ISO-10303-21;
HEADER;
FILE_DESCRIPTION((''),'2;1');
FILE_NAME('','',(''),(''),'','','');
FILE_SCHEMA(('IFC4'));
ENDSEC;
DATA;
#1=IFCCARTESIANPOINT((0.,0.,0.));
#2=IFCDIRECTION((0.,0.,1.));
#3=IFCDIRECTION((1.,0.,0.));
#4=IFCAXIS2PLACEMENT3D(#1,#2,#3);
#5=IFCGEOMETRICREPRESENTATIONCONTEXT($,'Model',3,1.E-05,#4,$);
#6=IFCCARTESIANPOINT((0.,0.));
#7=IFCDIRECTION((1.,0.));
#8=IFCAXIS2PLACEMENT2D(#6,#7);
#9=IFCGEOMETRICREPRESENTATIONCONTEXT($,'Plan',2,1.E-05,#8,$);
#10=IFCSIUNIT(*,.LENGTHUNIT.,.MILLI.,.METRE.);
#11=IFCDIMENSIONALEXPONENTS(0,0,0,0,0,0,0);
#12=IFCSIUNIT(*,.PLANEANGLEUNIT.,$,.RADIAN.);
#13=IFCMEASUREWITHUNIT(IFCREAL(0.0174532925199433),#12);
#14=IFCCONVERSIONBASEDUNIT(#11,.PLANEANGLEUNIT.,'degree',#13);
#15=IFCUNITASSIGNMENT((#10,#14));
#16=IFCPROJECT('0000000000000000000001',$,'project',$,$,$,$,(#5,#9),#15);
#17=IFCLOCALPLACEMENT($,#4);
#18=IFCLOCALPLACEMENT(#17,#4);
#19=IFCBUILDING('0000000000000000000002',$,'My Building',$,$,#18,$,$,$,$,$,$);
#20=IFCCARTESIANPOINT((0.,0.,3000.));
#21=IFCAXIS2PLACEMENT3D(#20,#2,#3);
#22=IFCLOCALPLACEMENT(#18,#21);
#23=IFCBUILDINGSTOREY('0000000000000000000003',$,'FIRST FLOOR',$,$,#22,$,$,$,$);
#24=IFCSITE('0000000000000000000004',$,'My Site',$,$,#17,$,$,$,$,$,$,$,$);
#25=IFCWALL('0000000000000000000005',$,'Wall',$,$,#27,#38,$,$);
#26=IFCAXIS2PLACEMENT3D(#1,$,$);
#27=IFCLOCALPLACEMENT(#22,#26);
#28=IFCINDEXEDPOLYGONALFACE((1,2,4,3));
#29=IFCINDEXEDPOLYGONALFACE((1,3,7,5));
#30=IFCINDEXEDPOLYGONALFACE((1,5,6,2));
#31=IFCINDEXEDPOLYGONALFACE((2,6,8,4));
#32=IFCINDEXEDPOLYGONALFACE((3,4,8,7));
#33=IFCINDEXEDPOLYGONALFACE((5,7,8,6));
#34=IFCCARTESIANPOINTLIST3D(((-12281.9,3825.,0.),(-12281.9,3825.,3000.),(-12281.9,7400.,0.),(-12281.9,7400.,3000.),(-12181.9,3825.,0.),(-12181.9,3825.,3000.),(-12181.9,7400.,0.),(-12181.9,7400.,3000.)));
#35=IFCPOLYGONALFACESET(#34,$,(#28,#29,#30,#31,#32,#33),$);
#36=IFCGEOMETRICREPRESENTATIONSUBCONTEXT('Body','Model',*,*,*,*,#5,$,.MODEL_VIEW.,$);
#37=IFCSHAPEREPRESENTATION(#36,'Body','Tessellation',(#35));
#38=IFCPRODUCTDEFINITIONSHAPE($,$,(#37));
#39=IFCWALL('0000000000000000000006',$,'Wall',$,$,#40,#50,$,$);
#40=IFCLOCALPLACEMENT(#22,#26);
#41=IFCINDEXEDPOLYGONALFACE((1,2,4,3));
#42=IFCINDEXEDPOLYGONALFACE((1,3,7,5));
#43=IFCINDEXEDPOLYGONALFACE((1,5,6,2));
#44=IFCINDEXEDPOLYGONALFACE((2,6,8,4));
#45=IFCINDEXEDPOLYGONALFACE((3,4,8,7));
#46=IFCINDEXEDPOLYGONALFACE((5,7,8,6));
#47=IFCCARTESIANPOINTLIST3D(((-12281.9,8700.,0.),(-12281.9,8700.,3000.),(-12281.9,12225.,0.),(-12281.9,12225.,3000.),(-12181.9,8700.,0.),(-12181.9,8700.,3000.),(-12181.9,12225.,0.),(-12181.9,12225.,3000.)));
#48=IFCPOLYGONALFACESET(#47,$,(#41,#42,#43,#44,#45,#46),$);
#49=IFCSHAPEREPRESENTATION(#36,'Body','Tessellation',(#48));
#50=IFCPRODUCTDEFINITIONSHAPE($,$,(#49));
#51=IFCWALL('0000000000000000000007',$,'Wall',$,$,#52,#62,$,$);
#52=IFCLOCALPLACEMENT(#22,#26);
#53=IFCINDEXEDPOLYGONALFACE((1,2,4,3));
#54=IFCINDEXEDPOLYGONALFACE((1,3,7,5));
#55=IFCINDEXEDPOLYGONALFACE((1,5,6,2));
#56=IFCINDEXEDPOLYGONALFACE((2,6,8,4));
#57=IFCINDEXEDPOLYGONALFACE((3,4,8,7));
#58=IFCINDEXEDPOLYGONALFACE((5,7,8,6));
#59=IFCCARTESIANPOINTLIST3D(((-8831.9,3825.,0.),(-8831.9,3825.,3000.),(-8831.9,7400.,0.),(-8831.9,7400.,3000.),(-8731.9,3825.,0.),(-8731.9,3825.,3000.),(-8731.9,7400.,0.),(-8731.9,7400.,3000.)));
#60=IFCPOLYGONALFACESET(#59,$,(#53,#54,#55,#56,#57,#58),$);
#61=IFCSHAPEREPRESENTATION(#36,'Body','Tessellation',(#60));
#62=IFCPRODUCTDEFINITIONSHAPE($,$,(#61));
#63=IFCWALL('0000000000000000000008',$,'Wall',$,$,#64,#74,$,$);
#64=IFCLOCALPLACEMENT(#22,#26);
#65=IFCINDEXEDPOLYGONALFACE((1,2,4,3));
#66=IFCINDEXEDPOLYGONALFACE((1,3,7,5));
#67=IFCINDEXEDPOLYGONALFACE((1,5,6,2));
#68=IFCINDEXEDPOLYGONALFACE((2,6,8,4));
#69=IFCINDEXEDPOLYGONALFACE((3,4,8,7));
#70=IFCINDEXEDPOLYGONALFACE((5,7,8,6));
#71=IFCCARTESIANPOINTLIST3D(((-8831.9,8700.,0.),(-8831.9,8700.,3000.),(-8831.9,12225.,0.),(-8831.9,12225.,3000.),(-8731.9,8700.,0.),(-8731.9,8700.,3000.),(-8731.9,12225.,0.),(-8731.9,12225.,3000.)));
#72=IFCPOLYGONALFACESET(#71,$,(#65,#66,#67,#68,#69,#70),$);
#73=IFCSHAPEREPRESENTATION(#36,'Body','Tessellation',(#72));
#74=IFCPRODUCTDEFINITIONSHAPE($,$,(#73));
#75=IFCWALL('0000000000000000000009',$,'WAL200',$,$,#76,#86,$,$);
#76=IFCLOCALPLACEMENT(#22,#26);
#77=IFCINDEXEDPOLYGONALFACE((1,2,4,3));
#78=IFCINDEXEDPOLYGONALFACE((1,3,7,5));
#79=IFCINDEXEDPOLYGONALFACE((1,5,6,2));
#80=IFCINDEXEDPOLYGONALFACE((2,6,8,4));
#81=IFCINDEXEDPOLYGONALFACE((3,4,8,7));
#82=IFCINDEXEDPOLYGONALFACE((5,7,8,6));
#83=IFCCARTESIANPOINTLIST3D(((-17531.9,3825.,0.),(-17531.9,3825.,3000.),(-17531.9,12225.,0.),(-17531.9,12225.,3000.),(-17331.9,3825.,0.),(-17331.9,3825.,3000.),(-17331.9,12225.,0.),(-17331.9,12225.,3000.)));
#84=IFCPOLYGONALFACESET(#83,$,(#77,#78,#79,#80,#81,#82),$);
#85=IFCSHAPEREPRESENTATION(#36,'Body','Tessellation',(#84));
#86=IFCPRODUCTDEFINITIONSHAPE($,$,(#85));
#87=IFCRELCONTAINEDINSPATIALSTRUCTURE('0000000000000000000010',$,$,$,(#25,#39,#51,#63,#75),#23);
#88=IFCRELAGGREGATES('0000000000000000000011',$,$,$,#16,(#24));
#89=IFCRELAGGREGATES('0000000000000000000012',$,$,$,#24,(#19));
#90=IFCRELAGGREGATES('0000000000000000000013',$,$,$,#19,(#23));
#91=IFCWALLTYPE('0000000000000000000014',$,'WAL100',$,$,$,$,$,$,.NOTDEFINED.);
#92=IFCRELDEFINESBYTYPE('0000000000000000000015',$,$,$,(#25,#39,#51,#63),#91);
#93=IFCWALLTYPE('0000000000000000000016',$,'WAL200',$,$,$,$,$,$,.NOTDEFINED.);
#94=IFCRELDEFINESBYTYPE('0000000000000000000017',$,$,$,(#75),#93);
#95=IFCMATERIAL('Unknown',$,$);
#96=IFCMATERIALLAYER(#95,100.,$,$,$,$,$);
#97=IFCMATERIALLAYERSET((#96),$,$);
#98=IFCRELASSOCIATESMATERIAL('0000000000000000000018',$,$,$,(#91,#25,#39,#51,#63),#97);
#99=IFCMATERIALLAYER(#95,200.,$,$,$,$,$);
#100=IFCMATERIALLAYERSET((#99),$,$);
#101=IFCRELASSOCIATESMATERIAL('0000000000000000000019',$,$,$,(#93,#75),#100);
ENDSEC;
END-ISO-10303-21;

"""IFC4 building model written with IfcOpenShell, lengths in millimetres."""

from ifc_helpers import new_model, entity, si_unit, converted_unit, frame, origin_with_axes, origin_2d_with_axis, place, context, subcontext, project, spatial, indexed_curve, outline, extrude, material, layer, layer_set, layer_usage, type_object, element, save


model = new_model("IFC4")

# Units and contexts
model_context = context("Model", 3, precision=1e-05, world=origin_with_axes())
plan_context = context("Plan", 2, precision=1e-05, world=origin_2d_with_axis())
body_context_1 = subcontext(model_context, "Body", "Model", "MODEL_VIEW")
ifc_project = project(units=[si_unit("LENGTHUNIT", "METRE", prefix="MILLI"), converted_unit("PLANEANGLEUNIT", "degree", entity("IfcReal", 0.0174532925199433), si_unit("PLANEANGLEUNIT", "RADIAN"), dimensions=[0, 0, 0, 0, 0, 0, 0])], contexts=[model_context, plan_context])

# Site, building, storey
site_placement = place(None, origin_with_axes())
site = spatial("IfcSite", under=ifc_project, at=site_placement, Name="My Site")
building_placement = place(site_placement, origin_with_axes())
building = spatial("IfcBuilding", under=site, at=building_placement, Name="My Building")
storey_placement = place(building_placement, frame((0.0, 0.0, 3000.0), z_axis=(0.0, 0.0, 1.0), x_axis=(1.0, 0.0, 0.0)))
storey = spatial("IfcBuildingStorey", under=building, at=storey_placement, Name="FIRST FLOOR")

# Shared definitions
ifc_material = material(Name="Unknown")

# Walls
ifc_layer_1 = layer(ifc_material, 100.0)
ifc_layer_set_1 = layer_set([ifc_layer_1])
wall_type_1 = type_object("IfcWallType", Name="WAL100", PredefinedType="NOTDEFINED", material=ifc_layer_set_1)
ifc_layer_usage_1 = layer_usage(ifc_layer_set_1, "AXIS2", "POSITIVE", 0.0)
wall_1_placement = place(storey_placement, frame((-12181.9, 3825.0, 0.0), z_axis=(0.0, 0.0, 1.0), x_axis=(0.000001, 1.0, 0.0)))
element("IfcWall", 1, at=wall_1_placement, inside=storey, type_object=wall_type_1, material=ifc_layer_usage_1, Name="Wall", context=body_context_1, shape_type="SweptSolid", body=[
    extrude(outline(indexed_curve([(0.0, 0.0), (0.0, 100.0), (3575.0, 100.0), (3575.0, 0.0), (0.0, 0.0)], self_intersect=False)), origin_with_axes(), (0.0, 0.0, 1.0), 3000.0),
])
ifc_layer_usage_2 = layer_usage(ifc_layer_set_1, "AXIS2", "POSITIVE", 0.0)
wall_2_placement = place(storey_placement, frame((-12181.9, 8700.0, 0.0), z_axis=(0.0, 0.0, 1.0), x_axis=(0.000001, 1.0, 0.0)))
element("IfcWall", 2, at=wall_2_placement, inside=storey, type_object=wall_type_1, material=ifc_layer_usage_2, Name="Wall", context=body_context_1, shape_type="SweptSolid", body=[
    extrude(outline(indexed_curve([(0.0, 0.0), (0.0, 100.0), (3525.0, 100.0), (3525.0, 0.0), (0.0, 0.0)], self_intersect=False)), origin_with_axes(), (0.0, 0.0, 1.0), 3000.0),
])
ifc_layer_usage_3 = layer_usage(ifc_layer_set_1, "AXIS2", "POSITIVE", 0.0)
wall_3_placement = place(storey_placement, frame((-8731.9, 3825.0, 0.0), z_axis=(0.0, 0.0, 1.0), x_axis=(0.000001, 1.0, 0.0)))
element("IfcWall", 3, at=wall_3_placement, inside=storey, type_object=wall_type_1, material=ifc_layer_usage_3, Name="Wall", context=body_context_1, shape_type="SweptSolid", body=[
    extrude(outline(indexed_curve([(0.0, 0.0), (0.0, 100.0), (3575.0, 100.0), (3575.0, 0.0), (0.0, 0.0)], self_intersect=False)), origin_with_axes(), (0.0, 0.0, 1.0), 3000.0),
])
ifc_layer_usage_4 = layer_usage(ifc_layer_set_1, "AXIS2", "POSITIVE", 0.0)
wall_4_placement = place(storey_placement, frame((-8731.9, 8700.0, 0.0), z_axis=(0.0, 0.0, 1.0), x_axis=(0.000001, 1.0, 0.0)))
element("IfcWall", 4, at=wall_4_placement, inside=storey, type_object=wall_type_1, material=ifc_layer_usage_4, Name="Wall", context=body_context_1, shape_type="SweptSolid", body=[
    extrude(outline(indexed_curve([(0.0, 0.0), (0.0, 100.0), (3525.0, 100.0), (3525.0, 0.0), (0.0, 0.0)], self_intersect=False)), origin_with_axes(), (0.0, 0.0, 1.0), 3000.0),
])
ifc_layer_2 = layer(ifc_material, 200.0)
ifc_layer_set_2 = layer_set([ifc_layer_2])
ifc_layer_usage_5 = layer_usage(ifc_layer_set_2, "AXIS2", "POSITIVE", 0.0)
wall_type_2 = type_object("IfcWallType", Name="WAL200", PredefinedType="NOTDEFINED", material=ifc_layer_set_2)
wall_5_placement = place(storey_placement, frame((-17331.9, 3825.0, 0.0), z_axis=(0.0, 0.0, 1.0), x_axis=(0.0, 1.0, 0.0)))
element("IfcWall", 5, at=wall_5_placement, inside=storey, type_object=wall_type_2, material=ifc_layer_usage_5, Name="WAL200", context=body_context_1, shape_type="SweptSolid", body=[
    extrude(outline(indexed_curve([(0.0, 0.0), (0.0, 200.0), (8400.0, 200.0), (8400.0, 0.0), (0.0, 0.0)], self_intersect=False)), origin_with_axes(), (0.0, 0.0, 1.0), 3000.0),
])

save(model, "model.ifc")
